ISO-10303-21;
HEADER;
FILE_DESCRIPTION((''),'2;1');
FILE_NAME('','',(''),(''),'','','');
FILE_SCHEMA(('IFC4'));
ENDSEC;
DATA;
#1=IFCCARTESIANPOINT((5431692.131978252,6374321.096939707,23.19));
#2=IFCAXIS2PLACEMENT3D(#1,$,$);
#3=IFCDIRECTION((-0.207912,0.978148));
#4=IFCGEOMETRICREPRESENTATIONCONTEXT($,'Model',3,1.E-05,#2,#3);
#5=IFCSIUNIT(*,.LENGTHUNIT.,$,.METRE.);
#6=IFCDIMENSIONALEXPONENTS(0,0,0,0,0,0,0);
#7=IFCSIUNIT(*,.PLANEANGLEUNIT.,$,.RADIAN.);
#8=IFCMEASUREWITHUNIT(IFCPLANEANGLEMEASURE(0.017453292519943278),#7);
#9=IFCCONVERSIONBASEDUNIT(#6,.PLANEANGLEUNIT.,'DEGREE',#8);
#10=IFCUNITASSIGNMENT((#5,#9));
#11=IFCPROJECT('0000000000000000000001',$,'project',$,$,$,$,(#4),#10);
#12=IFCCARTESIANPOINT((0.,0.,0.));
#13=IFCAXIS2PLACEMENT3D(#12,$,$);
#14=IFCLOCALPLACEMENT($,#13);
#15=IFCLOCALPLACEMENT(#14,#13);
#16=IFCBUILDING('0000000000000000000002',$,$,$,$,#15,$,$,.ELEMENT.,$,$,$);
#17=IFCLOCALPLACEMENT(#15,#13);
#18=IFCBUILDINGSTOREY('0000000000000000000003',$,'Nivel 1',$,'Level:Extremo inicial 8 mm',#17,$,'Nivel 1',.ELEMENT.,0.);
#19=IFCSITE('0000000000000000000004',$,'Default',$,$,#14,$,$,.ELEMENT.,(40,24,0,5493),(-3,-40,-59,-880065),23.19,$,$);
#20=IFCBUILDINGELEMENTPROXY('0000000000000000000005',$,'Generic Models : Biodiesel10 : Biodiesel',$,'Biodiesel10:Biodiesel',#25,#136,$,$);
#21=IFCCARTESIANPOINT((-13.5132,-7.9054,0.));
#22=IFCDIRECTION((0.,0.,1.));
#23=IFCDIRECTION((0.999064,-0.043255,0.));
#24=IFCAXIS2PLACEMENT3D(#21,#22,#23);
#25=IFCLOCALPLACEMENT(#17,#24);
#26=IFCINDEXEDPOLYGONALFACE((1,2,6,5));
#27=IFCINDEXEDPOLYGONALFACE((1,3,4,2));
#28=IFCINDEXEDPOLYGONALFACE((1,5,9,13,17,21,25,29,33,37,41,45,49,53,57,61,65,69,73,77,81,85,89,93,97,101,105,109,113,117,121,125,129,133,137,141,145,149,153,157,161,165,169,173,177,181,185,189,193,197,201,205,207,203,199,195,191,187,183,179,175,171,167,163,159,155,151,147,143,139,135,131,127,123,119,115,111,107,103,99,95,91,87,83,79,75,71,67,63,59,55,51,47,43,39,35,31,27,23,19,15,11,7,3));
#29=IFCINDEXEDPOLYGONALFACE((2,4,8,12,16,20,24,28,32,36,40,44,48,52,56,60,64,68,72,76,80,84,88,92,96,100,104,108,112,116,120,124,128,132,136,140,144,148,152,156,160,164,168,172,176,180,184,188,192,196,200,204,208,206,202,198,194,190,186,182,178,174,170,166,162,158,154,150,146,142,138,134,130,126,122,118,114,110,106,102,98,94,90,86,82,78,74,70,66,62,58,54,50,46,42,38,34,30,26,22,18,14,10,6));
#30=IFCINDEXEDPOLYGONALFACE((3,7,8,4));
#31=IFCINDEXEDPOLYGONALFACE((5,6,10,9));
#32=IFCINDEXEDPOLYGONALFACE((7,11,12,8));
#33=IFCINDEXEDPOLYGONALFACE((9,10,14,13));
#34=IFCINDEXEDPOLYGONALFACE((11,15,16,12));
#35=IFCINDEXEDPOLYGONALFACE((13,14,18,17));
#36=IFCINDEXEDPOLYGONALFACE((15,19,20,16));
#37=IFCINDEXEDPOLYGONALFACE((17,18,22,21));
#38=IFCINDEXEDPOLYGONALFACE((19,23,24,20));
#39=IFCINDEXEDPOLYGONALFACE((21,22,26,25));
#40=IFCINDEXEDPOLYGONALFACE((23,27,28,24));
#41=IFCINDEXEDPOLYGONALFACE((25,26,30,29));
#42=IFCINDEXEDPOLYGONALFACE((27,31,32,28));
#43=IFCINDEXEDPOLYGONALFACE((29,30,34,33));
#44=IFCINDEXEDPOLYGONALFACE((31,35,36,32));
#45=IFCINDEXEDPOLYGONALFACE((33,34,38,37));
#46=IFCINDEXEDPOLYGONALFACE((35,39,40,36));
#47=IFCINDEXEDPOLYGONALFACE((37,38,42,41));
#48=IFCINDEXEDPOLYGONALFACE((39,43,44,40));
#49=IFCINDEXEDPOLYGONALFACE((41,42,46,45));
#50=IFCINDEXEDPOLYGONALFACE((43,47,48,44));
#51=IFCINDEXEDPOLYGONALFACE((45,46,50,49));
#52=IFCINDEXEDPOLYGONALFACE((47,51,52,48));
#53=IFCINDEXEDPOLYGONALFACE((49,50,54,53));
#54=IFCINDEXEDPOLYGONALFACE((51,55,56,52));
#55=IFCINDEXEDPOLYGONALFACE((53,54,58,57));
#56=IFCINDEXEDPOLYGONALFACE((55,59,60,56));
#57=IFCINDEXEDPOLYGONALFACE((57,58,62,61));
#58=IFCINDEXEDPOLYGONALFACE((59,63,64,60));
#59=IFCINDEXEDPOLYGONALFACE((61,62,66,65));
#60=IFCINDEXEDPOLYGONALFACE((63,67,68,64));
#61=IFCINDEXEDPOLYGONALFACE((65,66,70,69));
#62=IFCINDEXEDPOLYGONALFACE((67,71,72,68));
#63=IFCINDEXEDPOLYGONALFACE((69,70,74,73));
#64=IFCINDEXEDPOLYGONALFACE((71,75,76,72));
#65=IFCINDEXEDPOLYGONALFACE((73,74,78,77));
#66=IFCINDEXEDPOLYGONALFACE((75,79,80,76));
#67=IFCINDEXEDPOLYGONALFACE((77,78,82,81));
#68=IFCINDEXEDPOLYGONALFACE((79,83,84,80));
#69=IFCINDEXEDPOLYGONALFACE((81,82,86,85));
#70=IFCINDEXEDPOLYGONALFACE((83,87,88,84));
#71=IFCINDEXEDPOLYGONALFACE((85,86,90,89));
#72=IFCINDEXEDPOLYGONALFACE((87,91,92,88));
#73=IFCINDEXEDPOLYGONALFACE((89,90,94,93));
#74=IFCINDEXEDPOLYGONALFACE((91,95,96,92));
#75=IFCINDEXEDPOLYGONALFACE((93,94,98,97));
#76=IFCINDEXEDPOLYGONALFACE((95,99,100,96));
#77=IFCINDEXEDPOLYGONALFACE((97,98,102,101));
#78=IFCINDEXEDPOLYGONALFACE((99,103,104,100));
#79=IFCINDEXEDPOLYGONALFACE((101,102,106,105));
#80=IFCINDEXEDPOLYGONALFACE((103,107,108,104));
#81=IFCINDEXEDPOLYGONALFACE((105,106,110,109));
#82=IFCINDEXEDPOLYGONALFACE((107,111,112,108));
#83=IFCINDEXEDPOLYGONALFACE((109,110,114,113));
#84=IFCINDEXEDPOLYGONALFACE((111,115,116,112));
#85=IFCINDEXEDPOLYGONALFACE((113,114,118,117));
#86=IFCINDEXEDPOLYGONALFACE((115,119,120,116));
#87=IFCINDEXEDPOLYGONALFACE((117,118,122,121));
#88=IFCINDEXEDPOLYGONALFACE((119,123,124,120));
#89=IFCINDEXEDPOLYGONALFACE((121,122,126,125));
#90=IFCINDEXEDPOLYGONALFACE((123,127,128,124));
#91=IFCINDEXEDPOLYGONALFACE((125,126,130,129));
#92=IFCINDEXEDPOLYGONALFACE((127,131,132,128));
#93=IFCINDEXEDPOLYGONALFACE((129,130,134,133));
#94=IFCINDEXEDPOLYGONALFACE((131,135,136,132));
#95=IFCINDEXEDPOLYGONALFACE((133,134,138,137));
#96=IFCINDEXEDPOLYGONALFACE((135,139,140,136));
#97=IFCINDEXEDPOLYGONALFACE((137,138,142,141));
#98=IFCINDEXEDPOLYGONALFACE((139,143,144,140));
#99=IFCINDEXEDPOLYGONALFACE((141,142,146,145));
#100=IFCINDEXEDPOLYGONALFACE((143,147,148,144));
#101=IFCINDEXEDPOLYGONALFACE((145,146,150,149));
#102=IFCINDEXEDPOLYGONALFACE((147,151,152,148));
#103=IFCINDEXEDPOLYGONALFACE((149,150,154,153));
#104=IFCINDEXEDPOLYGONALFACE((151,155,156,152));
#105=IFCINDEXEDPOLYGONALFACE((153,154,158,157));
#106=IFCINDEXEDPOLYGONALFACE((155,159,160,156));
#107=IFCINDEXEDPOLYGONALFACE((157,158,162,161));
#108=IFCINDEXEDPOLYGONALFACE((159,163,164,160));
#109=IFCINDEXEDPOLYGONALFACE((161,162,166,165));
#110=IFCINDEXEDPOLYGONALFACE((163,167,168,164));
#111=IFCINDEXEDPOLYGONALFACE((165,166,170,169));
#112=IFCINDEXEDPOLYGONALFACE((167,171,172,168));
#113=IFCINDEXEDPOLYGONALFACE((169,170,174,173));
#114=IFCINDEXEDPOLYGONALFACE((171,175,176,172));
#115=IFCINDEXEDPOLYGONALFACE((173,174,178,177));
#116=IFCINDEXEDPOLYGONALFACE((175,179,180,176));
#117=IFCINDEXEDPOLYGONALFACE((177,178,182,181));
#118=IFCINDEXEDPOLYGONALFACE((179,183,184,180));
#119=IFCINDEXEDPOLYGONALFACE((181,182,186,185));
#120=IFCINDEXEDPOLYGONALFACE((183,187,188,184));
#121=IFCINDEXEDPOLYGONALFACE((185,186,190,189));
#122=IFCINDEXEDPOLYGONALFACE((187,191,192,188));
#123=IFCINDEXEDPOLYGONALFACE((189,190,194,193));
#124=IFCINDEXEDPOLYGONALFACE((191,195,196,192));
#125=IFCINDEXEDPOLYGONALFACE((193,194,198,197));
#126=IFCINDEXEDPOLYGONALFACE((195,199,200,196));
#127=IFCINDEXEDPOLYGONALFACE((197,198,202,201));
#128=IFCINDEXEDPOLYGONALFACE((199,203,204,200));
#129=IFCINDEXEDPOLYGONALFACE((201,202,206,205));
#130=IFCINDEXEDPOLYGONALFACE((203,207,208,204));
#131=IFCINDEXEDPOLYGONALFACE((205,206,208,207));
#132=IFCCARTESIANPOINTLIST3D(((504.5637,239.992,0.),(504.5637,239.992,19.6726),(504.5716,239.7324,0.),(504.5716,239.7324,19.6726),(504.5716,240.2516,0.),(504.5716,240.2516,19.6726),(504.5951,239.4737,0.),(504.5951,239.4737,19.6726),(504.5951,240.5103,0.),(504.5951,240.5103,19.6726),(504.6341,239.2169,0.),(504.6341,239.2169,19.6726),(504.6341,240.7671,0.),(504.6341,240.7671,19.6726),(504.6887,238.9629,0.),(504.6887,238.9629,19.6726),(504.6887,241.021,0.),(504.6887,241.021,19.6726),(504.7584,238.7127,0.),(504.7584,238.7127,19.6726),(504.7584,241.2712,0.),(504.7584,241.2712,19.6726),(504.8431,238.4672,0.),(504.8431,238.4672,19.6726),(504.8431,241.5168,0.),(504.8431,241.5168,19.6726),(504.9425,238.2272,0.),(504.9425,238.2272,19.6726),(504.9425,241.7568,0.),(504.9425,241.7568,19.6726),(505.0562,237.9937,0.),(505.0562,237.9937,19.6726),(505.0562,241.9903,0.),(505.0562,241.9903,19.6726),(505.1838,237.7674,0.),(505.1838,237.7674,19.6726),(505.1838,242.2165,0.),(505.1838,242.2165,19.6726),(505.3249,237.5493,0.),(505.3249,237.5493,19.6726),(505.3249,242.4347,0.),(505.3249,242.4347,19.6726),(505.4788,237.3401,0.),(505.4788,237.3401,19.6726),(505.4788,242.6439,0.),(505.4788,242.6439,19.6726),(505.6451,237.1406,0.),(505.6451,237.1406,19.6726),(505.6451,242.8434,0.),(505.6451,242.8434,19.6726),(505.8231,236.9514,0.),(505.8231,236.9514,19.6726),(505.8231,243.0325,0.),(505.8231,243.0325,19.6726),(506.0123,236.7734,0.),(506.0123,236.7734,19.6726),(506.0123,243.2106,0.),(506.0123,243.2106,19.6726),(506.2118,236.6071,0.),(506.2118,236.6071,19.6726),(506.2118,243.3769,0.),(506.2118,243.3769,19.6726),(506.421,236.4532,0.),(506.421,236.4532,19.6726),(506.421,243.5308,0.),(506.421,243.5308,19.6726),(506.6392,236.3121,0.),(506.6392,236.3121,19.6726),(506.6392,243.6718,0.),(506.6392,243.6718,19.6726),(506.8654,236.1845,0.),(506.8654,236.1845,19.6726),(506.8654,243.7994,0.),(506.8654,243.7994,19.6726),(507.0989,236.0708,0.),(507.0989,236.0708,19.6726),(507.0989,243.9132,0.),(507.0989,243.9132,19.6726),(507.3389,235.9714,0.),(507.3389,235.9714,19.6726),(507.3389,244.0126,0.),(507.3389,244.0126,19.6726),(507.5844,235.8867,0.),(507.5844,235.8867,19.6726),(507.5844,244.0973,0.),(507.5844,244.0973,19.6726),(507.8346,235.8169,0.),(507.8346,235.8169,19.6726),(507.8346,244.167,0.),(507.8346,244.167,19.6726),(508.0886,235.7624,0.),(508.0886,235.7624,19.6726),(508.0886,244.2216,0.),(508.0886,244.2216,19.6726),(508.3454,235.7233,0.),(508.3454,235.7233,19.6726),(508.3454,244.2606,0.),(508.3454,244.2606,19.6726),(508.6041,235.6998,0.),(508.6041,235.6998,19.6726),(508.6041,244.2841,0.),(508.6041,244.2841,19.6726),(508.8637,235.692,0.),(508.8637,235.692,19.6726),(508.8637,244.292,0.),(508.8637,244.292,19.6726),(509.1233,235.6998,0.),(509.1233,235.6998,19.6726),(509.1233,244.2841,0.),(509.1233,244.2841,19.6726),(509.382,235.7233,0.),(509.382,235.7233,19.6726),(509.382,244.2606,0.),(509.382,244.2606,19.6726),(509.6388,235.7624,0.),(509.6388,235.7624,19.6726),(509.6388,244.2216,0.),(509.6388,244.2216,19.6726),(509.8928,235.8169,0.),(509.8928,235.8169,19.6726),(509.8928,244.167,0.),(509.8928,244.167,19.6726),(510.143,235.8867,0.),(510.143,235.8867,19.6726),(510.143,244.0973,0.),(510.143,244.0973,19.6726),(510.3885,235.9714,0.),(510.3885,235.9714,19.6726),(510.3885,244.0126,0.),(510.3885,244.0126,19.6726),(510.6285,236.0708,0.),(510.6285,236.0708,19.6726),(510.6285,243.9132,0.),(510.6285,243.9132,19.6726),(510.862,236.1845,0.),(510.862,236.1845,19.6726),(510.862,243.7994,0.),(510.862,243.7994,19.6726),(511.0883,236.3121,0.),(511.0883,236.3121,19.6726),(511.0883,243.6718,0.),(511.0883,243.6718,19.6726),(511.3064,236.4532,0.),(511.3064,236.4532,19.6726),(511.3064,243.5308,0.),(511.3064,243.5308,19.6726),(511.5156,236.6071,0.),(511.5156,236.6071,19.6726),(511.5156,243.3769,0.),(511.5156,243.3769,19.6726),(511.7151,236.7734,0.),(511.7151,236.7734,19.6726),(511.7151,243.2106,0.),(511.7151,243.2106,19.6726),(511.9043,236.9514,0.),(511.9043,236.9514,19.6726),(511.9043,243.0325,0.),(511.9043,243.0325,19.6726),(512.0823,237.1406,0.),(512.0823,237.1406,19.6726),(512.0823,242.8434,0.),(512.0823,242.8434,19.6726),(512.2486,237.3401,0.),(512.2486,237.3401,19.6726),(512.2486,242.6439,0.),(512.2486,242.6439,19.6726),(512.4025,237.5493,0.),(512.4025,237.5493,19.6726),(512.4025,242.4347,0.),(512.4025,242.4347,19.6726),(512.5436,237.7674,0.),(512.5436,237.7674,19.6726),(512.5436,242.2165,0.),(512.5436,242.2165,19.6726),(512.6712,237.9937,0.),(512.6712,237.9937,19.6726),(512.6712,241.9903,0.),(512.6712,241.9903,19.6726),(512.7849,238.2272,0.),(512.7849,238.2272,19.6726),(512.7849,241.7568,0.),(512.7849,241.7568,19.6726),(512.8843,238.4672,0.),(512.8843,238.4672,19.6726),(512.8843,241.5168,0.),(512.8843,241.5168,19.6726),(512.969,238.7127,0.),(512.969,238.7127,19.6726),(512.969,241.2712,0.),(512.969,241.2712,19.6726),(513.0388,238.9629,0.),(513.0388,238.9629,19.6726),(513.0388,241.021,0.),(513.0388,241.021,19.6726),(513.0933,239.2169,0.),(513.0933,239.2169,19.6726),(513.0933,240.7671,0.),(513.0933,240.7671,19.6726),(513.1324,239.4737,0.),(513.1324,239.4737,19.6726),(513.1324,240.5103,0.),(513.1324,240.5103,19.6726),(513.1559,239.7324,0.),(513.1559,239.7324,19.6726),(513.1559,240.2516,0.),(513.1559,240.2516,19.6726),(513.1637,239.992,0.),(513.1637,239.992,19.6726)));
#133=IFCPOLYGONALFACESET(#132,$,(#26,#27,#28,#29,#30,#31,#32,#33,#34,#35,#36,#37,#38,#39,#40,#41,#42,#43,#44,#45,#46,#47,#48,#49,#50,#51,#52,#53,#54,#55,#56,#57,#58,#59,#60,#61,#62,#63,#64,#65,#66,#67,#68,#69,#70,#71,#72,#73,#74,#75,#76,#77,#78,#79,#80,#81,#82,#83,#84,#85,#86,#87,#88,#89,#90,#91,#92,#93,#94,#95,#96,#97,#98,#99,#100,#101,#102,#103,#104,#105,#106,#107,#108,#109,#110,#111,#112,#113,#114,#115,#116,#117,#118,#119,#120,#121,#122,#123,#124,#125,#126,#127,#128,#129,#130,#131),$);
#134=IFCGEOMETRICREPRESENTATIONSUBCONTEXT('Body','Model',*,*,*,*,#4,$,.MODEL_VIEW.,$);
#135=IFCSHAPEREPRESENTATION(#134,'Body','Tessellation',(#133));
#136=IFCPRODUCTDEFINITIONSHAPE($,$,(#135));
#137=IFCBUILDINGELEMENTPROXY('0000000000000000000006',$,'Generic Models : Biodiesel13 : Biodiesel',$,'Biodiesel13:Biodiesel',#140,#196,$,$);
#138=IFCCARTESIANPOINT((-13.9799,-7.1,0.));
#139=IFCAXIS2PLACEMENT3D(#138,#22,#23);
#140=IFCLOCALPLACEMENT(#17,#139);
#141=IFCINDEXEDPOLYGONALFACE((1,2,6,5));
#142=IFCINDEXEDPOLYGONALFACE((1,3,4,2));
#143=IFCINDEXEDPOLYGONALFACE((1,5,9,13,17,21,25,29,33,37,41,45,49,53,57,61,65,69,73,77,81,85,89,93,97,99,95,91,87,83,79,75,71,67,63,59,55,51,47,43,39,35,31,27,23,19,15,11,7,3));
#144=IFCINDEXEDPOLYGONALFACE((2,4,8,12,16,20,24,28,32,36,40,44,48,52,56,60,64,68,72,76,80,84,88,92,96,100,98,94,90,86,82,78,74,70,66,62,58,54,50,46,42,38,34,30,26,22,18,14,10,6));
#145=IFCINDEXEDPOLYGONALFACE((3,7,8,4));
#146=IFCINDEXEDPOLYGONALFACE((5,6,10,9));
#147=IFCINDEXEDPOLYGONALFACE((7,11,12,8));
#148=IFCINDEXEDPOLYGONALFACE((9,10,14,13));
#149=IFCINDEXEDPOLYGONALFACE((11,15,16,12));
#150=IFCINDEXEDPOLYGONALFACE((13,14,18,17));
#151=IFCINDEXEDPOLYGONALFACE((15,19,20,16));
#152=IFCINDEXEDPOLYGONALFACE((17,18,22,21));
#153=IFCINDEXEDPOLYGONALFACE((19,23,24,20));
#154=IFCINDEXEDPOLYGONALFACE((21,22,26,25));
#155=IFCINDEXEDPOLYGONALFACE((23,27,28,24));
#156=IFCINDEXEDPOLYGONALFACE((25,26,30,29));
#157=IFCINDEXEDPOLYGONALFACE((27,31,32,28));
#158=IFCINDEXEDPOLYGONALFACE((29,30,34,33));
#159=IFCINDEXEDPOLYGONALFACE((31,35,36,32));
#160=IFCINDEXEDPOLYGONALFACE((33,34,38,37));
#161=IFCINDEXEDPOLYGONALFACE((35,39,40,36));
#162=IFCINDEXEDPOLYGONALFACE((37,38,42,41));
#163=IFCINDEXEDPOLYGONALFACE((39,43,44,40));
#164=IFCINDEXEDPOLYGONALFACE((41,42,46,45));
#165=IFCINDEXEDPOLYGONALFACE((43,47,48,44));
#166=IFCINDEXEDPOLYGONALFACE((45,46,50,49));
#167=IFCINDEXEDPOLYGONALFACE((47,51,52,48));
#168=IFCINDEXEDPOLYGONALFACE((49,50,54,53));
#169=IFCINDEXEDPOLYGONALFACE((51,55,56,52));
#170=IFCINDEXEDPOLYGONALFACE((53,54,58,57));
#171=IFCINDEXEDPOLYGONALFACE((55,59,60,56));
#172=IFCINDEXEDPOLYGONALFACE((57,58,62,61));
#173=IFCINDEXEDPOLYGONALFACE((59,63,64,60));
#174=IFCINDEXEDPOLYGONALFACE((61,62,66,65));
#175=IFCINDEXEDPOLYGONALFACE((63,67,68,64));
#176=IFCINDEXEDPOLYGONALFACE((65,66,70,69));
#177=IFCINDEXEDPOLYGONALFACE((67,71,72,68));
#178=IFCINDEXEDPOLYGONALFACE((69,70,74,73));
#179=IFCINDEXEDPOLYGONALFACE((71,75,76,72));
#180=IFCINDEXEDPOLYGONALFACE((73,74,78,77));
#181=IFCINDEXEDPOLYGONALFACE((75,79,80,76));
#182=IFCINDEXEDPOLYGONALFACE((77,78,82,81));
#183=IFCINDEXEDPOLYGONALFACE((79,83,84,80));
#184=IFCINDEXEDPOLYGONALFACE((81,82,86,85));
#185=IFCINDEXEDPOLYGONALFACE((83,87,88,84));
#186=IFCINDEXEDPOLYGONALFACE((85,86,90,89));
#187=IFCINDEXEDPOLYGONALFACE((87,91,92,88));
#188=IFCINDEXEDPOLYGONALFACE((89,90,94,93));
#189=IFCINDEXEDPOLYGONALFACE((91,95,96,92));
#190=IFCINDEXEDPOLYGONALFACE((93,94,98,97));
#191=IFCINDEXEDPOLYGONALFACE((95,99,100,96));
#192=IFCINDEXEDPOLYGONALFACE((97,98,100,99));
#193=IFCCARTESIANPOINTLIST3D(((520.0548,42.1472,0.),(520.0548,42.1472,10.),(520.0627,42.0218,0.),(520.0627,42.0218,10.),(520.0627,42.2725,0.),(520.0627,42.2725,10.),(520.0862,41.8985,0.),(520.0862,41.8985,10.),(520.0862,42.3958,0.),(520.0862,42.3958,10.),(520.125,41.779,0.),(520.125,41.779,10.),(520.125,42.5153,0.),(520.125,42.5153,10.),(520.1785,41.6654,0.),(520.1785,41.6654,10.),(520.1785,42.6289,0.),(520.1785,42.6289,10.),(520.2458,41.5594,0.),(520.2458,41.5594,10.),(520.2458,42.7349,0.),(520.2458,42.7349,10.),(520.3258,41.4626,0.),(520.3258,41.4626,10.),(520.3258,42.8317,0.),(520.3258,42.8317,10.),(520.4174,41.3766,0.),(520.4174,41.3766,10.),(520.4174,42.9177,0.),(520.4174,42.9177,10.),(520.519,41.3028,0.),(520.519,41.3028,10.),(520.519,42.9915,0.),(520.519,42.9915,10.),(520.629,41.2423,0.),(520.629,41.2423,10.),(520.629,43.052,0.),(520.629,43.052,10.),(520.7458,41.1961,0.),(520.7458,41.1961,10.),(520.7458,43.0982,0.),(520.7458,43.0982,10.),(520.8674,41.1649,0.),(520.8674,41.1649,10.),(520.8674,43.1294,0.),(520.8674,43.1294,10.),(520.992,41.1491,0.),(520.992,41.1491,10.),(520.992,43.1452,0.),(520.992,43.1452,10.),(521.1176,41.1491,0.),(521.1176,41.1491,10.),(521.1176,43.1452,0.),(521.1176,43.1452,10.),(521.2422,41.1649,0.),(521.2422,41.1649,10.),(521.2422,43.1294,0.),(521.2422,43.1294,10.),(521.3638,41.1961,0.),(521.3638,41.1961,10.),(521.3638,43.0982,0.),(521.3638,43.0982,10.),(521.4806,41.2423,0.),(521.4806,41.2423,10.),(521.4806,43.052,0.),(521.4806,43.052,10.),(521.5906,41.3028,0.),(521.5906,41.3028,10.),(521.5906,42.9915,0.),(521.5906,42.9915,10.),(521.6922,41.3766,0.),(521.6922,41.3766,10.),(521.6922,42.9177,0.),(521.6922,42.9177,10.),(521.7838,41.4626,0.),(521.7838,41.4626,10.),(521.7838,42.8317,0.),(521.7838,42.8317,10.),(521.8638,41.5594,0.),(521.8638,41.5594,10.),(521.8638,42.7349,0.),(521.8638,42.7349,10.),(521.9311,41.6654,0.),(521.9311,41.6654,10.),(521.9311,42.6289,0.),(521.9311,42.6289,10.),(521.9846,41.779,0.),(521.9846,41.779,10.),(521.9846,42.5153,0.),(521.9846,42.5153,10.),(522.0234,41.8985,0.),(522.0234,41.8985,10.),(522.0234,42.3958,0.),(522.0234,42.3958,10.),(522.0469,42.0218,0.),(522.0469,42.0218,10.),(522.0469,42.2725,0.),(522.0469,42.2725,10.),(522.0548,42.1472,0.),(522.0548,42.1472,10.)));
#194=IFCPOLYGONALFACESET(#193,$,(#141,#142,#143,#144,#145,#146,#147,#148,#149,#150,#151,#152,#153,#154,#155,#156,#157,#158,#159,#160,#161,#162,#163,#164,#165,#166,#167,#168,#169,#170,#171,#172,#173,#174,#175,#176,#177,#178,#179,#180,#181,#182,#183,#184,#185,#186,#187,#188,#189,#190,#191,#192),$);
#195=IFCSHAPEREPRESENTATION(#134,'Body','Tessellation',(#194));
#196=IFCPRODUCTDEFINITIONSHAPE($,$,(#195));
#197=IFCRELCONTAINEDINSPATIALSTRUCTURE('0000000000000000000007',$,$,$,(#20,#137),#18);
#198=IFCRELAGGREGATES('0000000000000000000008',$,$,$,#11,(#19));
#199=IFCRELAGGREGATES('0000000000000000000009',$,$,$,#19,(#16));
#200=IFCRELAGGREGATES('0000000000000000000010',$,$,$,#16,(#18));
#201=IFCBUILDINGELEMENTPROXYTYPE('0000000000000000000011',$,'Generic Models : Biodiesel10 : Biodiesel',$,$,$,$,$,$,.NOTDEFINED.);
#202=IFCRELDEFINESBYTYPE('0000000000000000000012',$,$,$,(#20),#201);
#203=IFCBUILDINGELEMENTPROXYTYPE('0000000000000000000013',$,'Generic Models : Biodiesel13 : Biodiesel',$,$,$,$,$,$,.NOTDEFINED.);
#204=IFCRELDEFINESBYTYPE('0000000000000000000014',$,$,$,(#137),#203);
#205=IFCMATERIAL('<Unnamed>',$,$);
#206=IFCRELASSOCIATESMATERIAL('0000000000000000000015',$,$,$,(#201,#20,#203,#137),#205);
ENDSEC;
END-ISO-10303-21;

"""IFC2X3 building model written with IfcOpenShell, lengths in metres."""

from ifc_helpers import new_model, entity, si_unit, converted_unit, direction, frame, origin, origin_2d_with_axis, place, context, subcontext, project, spatial, circle, extrude, source, transform, mapped, material, type_object, type_shapes, element, save


model = new_model("IFC2X3")

# Units and contexts
model_context = context("Model", 3, precision=1e-05, world=frame((5431692.131978252, 6374321.096939707, 23.19)), true_north=direction((-0.207912, 0.978148)))
body_context = subcontext(model_context, "Body", "Model", "MODEL_VIEW")
ifc_project = project(units=[si_unit("LENGTHUNIT", "METRE"), converted_unit("PLANEANGLEUNIT", "DEGREE", entity("IfcPlaneAngleMeasure", 0.017453292519943278), si_unit("PLANEANGLEUNIT", "RADIAN"), dimensions=[0, 0, 0, 0, 0, 0, 0])], contexts=[model_context])

# Site, building, storey
site_placement = place(None, origin())
site = spatial("IfcSite", under=ifc_project, at=site_placement, Name="Default", CompositionType="ELEMENT", RefLatitude=(40, 24, 0, 5493), RefLongitude=(-3, -40, -59, -880065), RefElevation=23.19)
building_placement = place(site_placement, origin())
building = spatial("IfcBuilding", under=site, at=building_placement, CompositionType="ELEMENT")
storey_placement = place(building_placement, origin())
storey = spatial("IfcBuildingStorey", under=building, at=storey_placement, Name="Nivel 1", ObjectType="Level:Extremo inicial 8 mm", LongName="Nivel 1", CompositionType="ELEMENT", Elevation=0.0)

# Building element proxies
ifc_material_1 = material(Name="<Unnamed>")
building_element_proxy_type_1 = type_object("IfcBuildingElementProxyType", Name="Generic Models : Biodiesel10 : Biodiesel", PredefinedType="NOTDEFINED", material=ifc_material_1)
shared_shape_1 = source(origin(), body_context, "Body", "SweptSolid", [
    extrude(circle(Radius=4.3, at=origin_2d_with_axis()), frame((508.8637, 239.992, 0.0)), (0.0, 0.0, 1.0), 19.6726),
])
type_shapes(building_element_proxy_type_1, [shared_shape_1])
proxy_1_placement = place(storey_placement, frame((-13.5132, -7.9054, 0.0), z_axis=(0.0, 0.0, 1.0), x_axis=(0.999064, -0.043255, 0.0)))
element("IfcBuildingElementProxy", 1, at=proxy_1_placement, inside=storey, type_object=building_element_proxy_type_1, material=ifc_material_1, Name="Generic Models : Biodiesel10 : Biodiesel", ObjectType="Biodiesel10:Biodiesel", context=body_context, shape_type="MappedRepresentation", body=[
    mapped(shared_shape_1, transform((0.0, 0.0, 0.0), scale=1.0)),
])
building_element_proxy_type_2 = type_object("IfcBuildingElementProxyType", Name="Generic Models : Biodiesel13 : Biodiesel", PredefinedType="NOTDEFINED", material=ifc_material_1)
shared_shape_2 = source(origin(), body_context, "Body", "SweptSolid", [
    extrude(circle(Radius=1.0, at=origin_2d_with_axis()), frame((521.0548, 42.1472, 0.0)), (0.0, 0.0, 1.0), 10.0),
])
type_shapes(building_element_proxy_type_2, [shared_shape_2])
proxy_2_placement = place(storey_placement, frame((-13.9799, -7.1, 0.0), z_axis=(0.0, 0.0, 1.0), x_axis=(0.999064, -0.043255, 0.0)))
element("IfcBuildingElementProxy", 2, at=proxy_2_placement, inside=storey, type_object=building_element_proxy_type_2, material=ifc_material_1, Name="Generic Models : Biodiesel13 : Biodiesel", ObjectType="Biodiesel13:Biodiesel", context=body_context, shape_type="MappedRepresentation", body=[
    mapped(shared_shape_2, transform((0.0, 0.0, 0.0), scale=1.0)),
])

save(model, "model.ifc")
